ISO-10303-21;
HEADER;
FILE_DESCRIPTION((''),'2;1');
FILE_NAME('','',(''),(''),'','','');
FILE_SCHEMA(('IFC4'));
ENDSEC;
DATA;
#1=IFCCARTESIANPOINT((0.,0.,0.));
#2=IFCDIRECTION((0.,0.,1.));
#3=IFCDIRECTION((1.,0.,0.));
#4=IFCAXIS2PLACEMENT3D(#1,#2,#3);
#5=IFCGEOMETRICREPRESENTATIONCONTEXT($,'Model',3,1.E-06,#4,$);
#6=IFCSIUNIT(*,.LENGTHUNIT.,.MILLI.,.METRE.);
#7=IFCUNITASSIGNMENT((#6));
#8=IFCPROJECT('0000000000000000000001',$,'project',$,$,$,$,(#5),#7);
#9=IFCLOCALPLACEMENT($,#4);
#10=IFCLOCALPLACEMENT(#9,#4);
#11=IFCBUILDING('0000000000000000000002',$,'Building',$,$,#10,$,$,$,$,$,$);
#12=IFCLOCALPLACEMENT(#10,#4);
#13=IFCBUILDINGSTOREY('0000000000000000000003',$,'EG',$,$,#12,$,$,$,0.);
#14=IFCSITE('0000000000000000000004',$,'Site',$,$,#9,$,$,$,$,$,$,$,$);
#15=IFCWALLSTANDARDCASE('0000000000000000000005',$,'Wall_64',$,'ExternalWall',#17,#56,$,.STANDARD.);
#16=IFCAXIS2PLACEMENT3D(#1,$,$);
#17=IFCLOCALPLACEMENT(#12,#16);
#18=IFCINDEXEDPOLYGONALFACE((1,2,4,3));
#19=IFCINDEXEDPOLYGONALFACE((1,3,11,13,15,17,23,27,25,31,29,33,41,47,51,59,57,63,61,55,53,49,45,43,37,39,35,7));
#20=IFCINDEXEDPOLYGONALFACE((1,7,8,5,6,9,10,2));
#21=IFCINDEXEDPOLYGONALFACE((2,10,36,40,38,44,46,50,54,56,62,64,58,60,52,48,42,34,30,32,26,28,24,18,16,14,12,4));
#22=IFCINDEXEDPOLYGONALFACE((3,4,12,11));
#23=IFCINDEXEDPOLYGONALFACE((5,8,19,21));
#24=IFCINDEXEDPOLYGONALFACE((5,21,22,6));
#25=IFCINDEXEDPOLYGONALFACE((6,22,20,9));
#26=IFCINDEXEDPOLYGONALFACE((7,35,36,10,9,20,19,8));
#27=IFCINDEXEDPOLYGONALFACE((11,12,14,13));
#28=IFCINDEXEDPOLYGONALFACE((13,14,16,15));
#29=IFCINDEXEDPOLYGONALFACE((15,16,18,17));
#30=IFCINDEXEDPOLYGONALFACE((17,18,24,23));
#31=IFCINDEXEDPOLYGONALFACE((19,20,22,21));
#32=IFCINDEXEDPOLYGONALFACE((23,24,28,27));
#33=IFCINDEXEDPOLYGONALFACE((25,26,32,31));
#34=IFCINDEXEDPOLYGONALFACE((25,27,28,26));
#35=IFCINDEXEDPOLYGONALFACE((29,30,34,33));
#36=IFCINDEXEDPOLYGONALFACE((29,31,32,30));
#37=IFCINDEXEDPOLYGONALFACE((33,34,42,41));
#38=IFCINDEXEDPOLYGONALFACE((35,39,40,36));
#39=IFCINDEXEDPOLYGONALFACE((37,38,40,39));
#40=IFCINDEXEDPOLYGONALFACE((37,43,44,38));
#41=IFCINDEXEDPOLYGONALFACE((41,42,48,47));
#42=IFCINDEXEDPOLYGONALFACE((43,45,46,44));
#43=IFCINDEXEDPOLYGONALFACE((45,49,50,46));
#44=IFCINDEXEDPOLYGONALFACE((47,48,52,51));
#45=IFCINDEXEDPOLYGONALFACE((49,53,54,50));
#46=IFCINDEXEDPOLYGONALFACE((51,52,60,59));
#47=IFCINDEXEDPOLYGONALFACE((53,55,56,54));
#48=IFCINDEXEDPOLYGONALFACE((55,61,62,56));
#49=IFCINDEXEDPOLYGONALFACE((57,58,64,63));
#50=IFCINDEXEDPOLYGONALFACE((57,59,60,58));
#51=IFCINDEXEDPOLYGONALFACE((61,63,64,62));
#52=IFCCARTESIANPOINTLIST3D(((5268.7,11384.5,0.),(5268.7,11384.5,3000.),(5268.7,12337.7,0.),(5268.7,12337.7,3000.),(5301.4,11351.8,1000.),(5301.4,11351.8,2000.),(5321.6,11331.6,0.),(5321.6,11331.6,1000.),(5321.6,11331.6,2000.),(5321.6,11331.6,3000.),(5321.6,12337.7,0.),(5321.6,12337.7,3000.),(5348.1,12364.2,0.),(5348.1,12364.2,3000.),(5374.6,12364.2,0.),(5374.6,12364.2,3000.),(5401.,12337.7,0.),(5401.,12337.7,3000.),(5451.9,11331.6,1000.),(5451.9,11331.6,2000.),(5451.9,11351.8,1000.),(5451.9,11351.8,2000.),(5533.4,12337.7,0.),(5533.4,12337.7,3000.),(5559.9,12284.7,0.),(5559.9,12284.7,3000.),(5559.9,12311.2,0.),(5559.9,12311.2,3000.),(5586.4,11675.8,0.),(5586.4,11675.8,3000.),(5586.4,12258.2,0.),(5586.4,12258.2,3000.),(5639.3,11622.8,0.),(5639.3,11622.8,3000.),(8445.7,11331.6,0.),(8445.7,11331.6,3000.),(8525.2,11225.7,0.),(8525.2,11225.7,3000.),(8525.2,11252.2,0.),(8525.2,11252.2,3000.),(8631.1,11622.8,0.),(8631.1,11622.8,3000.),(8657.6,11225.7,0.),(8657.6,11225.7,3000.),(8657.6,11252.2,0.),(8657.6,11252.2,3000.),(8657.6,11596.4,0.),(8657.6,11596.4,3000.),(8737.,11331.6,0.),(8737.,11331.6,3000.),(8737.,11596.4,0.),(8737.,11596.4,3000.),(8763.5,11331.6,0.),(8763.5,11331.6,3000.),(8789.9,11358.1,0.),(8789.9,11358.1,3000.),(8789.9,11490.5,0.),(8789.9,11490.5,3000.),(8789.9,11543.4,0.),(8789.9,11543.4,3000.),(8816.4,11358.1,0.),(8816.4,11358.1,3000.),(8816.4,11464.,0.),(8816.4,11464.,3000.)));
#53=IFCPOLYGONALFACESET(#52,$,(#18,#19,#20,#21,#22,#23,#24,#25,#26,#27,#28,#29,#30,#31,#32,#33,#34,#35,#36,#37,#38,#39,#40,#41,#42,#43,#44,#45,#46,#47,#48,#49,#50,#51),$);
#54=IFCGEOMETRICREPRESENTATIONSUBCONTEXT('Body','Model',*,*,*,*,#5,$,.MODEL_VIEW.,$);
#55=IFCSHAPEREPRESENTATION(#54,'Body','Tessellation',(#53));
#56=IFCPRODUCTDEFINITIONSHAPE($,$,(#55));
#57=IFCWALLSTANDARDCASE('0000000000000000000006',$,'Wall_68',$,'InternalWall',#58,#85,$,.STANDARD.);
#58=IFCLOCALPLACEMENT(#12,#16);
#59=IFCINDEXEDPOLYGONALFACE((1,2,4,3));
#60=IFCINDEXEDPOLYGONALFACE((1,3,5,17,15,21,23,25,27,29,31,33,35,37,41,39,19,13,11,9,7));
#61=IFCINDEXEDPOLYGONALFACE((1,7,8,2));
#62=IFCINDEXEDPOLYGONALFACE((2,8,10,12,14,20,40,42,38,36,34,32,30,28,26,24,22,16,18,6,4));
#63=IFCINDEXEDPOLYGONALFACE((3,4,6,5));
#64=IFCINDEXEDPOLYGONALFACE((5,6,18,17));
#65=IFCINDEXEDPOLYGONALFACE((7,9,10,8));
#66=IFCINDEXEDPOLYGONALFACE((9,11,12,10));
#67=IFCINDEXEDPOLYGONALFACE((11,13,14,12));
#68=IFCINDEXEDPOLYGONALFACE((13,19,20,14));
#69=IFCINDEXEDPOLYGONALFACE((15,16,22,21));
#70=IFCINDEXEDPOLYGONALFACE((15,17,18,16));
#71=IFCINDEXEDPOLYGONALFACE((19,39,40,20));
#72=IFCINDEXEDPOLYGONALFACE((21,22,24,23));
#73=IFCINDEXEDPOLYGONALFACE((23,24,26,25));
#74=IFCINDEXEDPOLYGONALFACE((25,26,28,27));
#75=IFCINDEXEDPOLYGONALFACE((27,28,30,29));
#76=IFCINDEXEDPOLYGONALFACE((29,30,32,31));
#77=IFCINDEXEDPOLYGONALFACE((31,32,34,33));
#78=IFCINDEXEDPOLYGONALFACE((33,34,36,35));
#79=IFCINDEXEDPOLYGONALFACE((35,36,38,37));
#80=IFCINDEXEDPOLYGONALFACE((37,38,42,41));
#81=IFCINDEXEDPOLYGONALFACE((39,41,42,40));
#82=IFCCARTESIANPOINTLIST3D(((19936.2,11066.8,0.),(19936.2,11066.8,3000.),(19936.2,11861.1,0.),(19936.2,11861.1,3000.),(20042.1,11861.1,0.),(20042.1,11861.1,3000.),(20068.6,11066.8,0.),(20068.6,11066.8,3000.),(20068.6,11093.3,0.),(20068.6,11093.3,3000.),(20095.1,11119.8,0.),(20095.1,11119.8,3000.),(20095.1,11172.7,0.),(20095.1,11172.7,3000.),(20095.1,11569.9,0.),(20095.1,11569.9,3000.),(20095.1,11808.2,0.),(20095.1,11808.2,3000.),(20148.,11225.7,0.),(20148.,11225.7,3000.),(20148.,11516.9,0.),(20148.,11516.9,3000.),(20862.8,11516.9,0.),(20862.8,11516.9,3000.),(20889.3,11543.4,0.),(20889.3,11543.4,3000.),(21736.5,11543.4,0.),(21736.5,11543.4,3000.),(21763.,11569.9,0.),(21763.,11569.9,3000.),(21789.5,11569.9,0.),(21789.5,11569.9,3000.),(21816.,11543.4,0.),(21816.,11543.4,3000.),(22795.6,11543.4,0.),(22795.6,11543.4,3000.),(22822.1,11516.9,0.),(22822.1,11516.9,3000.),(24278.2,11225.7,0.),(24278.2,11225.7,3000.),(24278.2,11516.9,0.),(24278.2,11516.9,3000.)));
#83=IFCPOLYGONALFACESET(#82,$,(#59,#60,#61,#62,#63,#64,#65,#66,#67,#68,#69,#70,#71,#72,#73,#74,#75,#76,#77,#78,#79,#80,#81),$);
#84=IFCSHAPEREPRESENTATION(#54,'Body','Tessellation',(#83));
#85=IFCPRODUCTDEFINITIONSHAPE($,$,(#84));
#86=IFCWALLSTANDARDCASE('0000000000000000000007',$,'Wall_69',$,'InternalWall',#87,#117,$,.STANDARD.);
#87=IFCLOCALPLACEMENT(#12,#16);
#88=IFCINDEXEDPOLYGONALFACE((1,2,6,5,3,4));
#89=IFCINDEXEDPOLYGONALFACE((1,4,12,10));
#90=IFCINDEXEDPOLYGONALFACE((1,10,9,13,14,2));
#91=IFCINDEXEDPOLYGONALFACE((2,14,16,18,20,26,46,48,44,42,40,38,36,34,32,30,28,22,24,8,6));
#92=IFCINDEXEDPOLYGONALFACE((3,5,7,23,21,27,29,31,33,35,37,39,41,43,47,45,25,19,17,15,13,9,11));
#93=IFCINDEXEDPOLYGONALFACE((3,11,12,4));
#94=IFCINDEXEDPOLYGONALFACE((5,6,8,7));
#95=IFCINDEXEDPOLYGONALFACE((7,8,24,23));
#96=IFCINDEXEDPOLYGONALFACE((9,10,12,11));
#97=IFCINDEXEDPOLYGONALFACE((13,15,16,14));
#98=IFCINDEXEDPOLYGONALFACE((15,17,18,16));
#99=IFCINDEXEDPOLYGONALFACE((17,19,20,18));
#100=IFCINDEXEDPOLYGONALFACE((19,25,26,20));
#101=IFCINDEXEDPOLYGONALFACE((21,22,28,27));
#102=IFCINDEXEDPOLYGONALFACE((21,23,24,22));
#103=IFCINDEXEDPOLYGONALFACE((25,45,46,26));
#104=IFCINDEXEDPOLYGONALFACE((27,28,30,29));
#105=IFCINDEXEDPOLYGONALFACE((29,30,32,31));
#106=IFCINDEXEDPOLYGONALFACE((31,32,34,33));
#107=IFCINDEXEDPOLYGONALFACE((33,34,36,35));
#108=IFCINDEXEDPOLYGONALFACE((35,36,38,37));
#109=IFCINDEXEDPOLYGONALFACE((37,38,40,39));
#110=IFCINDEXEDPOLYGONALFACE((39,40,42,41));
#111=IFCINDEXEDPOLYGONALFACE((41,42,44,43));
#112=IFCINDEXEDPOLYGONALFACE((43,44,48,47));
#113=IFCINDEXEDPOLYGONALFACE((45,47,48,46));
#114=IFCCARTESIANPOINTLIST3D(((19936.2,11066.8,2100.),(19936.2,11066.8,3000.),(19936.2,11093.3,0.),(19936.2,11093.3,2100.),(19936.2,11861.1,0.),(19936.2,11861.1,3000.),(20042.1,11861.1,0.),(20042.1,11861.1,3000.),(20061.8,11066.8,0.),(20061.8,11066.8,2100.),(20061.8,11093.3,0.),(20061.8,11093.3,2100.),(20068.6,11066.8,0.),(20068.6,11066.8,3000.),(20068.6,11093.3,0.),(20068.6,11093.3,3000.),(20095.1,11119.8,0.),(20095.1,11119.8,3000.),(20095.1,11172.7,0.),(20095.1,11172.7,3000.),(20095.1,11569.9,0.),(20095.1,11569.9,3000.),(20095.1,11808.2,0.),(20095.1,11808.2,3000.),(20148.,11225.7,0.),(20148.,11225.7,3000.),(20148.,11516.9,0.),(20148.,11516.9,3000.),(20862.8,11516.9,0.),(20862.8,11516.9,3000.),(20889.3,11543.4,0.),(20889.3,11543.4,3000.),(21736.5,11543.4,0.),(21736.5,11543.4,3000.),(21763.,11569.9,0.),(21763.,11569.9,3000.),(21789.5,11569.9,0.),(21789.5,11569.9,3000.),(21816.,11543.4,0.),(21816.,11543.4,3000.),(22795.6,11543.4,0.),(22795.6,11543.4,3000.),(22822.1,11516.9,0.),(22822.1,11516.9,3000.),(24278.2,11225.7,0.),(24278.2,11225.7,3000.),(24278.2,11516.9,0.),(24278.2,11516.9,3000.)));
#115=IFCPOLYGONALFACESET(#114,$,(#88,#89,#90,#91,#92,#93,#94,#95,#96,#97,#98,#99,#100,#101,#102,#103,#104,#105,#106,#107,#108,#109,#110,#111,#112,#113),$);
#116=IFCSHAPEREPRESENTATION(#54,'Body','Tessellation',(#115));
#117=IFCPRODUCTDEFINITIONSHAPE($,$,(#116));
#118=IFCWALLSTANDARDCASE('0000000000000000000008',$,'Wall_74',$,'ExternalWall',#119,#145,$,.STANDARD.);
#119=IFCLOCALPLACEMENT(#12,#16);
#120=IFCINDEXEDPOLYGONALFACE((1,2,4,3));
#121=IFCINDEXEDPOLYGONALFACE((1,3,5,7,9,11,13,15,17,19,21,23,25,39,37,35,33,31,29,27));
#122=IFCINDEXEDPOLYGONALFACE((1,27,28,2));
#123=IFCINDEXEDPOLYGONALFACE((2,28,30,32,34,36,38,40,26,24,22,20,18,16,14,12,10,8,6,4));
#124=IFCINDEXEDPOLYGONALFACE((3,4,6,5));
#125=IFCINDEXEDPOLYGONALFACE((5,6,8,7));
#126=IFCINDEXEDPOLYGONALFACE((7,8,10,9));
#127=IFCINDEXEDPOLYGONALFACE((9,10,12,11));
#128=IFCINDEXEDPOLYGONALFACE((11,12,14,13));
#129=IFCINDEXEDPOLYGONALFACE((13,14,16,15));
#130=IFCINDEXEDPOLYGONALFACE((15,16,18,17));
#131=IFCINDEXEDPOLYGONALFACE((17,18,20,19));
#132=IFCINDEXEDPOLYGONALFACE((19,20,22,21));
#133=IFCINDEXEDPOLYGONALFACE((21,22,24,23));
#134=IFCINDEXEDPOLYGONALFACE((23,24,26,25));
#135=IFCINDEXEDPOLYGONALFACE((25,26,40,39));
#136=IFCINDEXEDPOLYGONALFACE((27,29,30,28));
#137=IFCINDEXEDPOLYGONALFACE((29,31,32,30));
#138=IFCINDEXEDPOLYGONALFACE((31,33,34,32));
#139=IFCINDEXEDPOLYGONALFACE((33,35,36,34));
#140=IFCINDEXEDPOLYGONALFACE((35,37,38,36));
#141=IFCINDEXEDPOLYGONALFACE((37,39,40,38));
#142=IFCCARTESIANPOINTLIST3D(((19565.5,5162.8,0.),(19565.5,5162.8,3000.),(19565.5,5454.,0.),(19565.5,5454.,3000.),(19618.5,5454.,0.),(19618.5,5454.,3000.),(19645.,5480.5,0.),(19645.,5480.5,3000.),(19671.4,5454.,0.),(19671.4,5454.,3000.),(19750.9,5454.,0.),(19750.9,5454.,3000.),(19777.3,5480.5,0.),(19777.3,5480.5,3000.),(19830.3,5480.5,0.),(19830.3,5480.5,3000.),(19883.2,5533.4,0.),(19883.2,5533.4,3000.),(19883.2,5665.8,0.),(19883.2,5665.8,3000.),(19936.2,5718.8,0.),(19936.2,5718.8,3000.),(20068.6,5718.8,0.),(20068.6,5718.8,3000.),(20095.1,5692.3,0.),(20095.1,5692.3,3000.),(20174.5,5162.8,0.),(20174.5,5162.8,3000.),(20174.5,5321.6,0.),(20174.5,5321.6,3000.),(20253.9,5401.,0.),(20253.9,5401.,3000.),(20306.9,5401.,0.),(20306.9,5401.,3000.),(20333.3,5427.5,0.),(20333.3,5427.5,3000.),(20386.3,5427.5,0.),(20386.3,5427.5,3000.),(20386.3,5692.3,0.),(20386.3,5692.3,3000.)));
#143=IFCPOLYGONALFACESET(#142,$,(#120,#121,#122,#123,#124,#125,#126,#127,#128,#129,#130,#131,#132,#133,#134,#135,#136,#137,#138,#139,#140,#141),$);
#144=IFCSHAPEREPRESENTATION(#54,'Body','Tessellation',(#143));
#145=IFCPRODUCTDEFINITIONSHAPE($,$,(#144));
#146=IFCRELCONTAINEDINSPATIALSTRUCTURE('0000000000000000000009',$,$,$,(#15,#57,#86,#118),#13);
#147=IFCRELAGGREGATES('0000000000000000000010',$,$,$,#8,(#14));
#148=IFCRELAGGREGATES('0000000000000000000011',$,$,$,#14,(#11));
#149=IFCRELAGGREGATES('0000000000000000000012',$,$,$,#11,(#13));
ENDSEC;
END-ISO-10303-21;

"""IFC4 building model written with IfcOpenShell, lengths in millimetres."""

from ifc_helpers import new_model, si_unit, frame, origin_with_axes, place, context, subcontext, project, spatial, polyline, rectangle, outline, extrude, element, save


model = new_model("IFC4")

# Units and contexts
model_context = context("Model", 3, precision=1e-06, world=origin_with_axes())
body_context = subcontext(model_context, "Body", "Model", "MODEL_VIEW")
ifc_project = project(units=[si_unit("LENGTHUNIT", "METRE", prefix="MILLI")], contexts=[model_context])

# Site, building, storey
site_placement = place(None, origin_with_axes())
site = spatial("IfcSite", under=ifc_project, at=site_placement, Name="Site")
building_placement = place(site_placement, origin_with_axes())
building = spatial("IfcBuilding", under=site, at=building_placement, Name="Building")
storey_placement = place(building_placement, origin_with_axes())
storey = spatial("IfcBuildingStorey", under=building, at=storey_placement, Name="EG", Elevation=0.0)

# Wall, opening
wall_1_placement = place(storey_placement, origin_with_axes())
wall_1 = element("IfcWallStandardCase", 1, at=wall_1_placement, inside=storey, Name="Wall_64", ObjectType="ExternalWall", PredefinedType="STANDARD", context=body_context, shape_type="SweptSolid", body=[
    extrude(outline(polyline([(8525.2, 11225.7, 0.0), (8525.2, 11252.2, 0.0), (8445.7, 11331.6, 0.0), (5321.6, 11331.6, 0.0), (5268.7, 11384.5, 0.0), (5268.7, 12337.7, 0.0), (5321.6, 12337.7, 0.0), (5348.1, 12364.2, 0.0), (5374.6, 12364.2, 0.0), (5401.0, 12337.7, 0.0), (5533.4, 12337.7, 0.0), (5559.9, 12311.2, 0.0), (5559.9, 12284.7, 0.0), (5586.4, 12258.2, 0.0), (5586.4, 11675.8, 0.0), (5639.3, 11622.8, 0.0), (8631.1, 11622.8, 0.0), (8657.6, 11596.4, 0.0), (8737.0, 11596.4, 0.0), (8789.9, 11543.4, 0.0), (8789.9, 11490.5, 0.0), (8816.4, 11464.0, 0.0), (8816.4, 11358.1, 0.0), (8789.9, 11358.1, 0.0), (8763.5, 11331.6, 0.0), (8737.0, 11331.6, 0.0), (8657.6, 11252.2, 0.0), (8657.6, 11225.7, 0.0), (8525.2, 11225.7, 0.0)])), origin_with_axes(), (0.0, 0.0, 1.0), 3000.0),
])
opening_1_placement = place(wall_1_placement, origin_with_axes())
element("IfcOpeningElement", 2, at=opening_1_placement, inside=storey, cuts=wall_1, context=body_context, shape_type="SweptSolid", body=[
    extrude(rectangle(XDim=636.5, YDim=300.0), frame((5133.7, 11201.8, 1000.0), z_axis=(0.0, 0.0, 1.0), x_axis=(1.0, 0.0, 0.0)), (0.0, 0.0, 1.0), 1000.0),
])

# Wall
wall_2_placement = place(storey_placement, origin_with_axes())
element("IfcWallStandardCase", 3, at=wall_2_placement, inside=storey, Name="Wall_68", ObjectType="InternalWall", PredefinedType="STANDARD", context=body_context, shape_type="SweptSolid", body=[
    extrude(outline(polyline([(19936.2, 11066.8, 0.0), (19936.2, 11861.1, 0.0), (20042.1, 11861.1, 0.0), (20095.1, 11808.2, 0.0), (20095.1, 11569.9, 0.0), (20148.0, 11516.9, 0.0), (20862.8, 11516.9, 0.0), (20889.3, 11543.4, 0.0), (21736.5, 11543.4, 0.0), (21763.0, 11569.9, 0.0), (21789.5, 11569.9, 0.0), (21816.0, 11543.4, 0.0), (22795.6, 11543.4, 0.0), (22822.1, 11516.9, 0.0), (24278.2, 11516.9, 0.0), (24278.2, 11225.7, 0.0), (20148.0, 11225.7, 0.0), (20095.1, 11172.7, 0.0), (20095.1, 11119.8, 0.0), (20068.6, 11093.3, 0.0), (20068.6, 11066.8, 0.0), (19936.2, 11066.8, 0.0)])), origin_with_axes(), (0.0, 0.0, 1.0), 3000.0),
])

# Wall, openings
wall_3_placement = place(storey_placement, origin_with_axes())
wall_3 = element("IfcWallStandardCase", 4, at=wall_3_placement, inside=storey, Name="Wall_69", ObjectType="InternalWall", PredefinedType="STANDARD", context=body_context, shape_type="SweptSolid", body=[
    extrude(outline(polyline([(19936.2, 11066.8, 0.0), (19936.2, 11861.1, 0.0), (20042.1, 11861.1, 0.0), (20095.1, 11808.2, 0.0), (20095.1, 11569.9, 0.0), (20148.0, 11516.9, 0.0), (20862.8, 11516.9, 0.0), (20889.3, 11543.4, 0.0), (21736.5, 11543.4, 0.0), (21763.0, 11569.9, 0.0), (21789.5, 11569.9, 0.0), (21816.0, 11543.4, 0.0), (22795.6, 11543.4, 0.0), (22822.1, 11516.9, 0.0), (24278.2, 11516.9, 0.0), (24278.2, 11225.7, 0.0), (20148.0, 11225.7, 0.0), (20095.1, 11172.7, 0.0), (20095.1, 11119.8, 0.0), (20068.6, 11093.3, 0.0), (20068.6, 11066.8, 0.0), (19936.2, 11066.8, 0.0)])), origin_with_axes(), (0.0, 0.0, 1.0), 3000.0),
])
opening_2_placement = place(wall_3_placement, origin_with_axes())
element("IfcOpeningElement", 5, at=opening_2_placement, inside=storey, cuts=wall_3, context=body_context, shape_type="SweptSolid", body=[
    extrude(rectangle(XDim=1059.0, YDim=240.0), frame((19941.8, 10563.8, 0.0), z_axis=(0.0, 0.0, 1.0), x_axis=(0.0, 1.0, 0.0)), (0.0, 0.0, 1.0), 2100.0),
])
opening_3_placement = place(wall_3_placement, origin_with_axes())
element("IfcOpeningElement", 6, at=opening_3_placement, inside=storey, cuts=wall_3, context=body_context, shape_type="SweptSolid", body=[
    extrude(rectangle(XDim=847.2, YDim=240.0), frame((19941.8, 12284.7, 0.0), z_axis=(0.0, 0.0, 1.0), x_axis=(0.0, 1.0, 0.0)), (0.0, 0.0, 1.0), 2100.0),
])

# Wall, opening
wall_4_placement = place(storey_placement, origin_with_axes())
wall_4 = element("IfcWallStandardCase", 7, at=wall_4_placement, inside=storey, Name="Wall_74", ObjectType="ExternalWall", PredefinedType="STANDARD", context=body_context, shape_type="SweptSolid", body=[
    extrude(outline(polyline([(19565.5, 5162.8, 0.0), (19565.5, 5454.0, 0.0), (19618.5, 5454.0, 0.0), (19645.0, 5480.5, 0.0), (19671.4, 5454.0, 0.0), (19750.9, 5454.0, 0.0), (19777.3, 5480.5, 0.0), (19830.3, 5480.5, 0.0), (19883.2, 5533.4, 0.0), (19883.2, 5665.8, 0.0), (19936.2, 5718.8, 0.0), (20068.6, 5718.8, 0.0), (20095.1, 5692.3, 0.0), (20386.3, 5692.3, 0.0), (20386.3, 5427.5, 0.0), (20333.3, 5427.5, 0.0), (20306.9, 5401.0, 0.0), (20253.9, 5401.0, 0.0), (20174.5, 5321.6, 0.0), (20174.5, 5162.8, 0.0), (19565.5, 5162.8, 0.0)])), origin_with_axes(), (0.0, 0.0, 1.0), 3000.0),
])
opening_4_placement = place(wall_4_placement, origin_with_axes())
element("IfcOpeningElement", 8, at=opening_4_placement, inside=storey, cuts=wall_4, context=body_context, shape_type="SweptSolid", body=[
    extrude(rectangle(XDim=2956.0, YDim=240.0), frame((21457.7, 6536.9, 1000.0), z_axis=(0.0, 0.0, 1.0), x_axis=(1.0, 0.0, 0.0)), (0.0, 0.0, 1.0), 1000.0),
])

save(model, "model.ifc")
